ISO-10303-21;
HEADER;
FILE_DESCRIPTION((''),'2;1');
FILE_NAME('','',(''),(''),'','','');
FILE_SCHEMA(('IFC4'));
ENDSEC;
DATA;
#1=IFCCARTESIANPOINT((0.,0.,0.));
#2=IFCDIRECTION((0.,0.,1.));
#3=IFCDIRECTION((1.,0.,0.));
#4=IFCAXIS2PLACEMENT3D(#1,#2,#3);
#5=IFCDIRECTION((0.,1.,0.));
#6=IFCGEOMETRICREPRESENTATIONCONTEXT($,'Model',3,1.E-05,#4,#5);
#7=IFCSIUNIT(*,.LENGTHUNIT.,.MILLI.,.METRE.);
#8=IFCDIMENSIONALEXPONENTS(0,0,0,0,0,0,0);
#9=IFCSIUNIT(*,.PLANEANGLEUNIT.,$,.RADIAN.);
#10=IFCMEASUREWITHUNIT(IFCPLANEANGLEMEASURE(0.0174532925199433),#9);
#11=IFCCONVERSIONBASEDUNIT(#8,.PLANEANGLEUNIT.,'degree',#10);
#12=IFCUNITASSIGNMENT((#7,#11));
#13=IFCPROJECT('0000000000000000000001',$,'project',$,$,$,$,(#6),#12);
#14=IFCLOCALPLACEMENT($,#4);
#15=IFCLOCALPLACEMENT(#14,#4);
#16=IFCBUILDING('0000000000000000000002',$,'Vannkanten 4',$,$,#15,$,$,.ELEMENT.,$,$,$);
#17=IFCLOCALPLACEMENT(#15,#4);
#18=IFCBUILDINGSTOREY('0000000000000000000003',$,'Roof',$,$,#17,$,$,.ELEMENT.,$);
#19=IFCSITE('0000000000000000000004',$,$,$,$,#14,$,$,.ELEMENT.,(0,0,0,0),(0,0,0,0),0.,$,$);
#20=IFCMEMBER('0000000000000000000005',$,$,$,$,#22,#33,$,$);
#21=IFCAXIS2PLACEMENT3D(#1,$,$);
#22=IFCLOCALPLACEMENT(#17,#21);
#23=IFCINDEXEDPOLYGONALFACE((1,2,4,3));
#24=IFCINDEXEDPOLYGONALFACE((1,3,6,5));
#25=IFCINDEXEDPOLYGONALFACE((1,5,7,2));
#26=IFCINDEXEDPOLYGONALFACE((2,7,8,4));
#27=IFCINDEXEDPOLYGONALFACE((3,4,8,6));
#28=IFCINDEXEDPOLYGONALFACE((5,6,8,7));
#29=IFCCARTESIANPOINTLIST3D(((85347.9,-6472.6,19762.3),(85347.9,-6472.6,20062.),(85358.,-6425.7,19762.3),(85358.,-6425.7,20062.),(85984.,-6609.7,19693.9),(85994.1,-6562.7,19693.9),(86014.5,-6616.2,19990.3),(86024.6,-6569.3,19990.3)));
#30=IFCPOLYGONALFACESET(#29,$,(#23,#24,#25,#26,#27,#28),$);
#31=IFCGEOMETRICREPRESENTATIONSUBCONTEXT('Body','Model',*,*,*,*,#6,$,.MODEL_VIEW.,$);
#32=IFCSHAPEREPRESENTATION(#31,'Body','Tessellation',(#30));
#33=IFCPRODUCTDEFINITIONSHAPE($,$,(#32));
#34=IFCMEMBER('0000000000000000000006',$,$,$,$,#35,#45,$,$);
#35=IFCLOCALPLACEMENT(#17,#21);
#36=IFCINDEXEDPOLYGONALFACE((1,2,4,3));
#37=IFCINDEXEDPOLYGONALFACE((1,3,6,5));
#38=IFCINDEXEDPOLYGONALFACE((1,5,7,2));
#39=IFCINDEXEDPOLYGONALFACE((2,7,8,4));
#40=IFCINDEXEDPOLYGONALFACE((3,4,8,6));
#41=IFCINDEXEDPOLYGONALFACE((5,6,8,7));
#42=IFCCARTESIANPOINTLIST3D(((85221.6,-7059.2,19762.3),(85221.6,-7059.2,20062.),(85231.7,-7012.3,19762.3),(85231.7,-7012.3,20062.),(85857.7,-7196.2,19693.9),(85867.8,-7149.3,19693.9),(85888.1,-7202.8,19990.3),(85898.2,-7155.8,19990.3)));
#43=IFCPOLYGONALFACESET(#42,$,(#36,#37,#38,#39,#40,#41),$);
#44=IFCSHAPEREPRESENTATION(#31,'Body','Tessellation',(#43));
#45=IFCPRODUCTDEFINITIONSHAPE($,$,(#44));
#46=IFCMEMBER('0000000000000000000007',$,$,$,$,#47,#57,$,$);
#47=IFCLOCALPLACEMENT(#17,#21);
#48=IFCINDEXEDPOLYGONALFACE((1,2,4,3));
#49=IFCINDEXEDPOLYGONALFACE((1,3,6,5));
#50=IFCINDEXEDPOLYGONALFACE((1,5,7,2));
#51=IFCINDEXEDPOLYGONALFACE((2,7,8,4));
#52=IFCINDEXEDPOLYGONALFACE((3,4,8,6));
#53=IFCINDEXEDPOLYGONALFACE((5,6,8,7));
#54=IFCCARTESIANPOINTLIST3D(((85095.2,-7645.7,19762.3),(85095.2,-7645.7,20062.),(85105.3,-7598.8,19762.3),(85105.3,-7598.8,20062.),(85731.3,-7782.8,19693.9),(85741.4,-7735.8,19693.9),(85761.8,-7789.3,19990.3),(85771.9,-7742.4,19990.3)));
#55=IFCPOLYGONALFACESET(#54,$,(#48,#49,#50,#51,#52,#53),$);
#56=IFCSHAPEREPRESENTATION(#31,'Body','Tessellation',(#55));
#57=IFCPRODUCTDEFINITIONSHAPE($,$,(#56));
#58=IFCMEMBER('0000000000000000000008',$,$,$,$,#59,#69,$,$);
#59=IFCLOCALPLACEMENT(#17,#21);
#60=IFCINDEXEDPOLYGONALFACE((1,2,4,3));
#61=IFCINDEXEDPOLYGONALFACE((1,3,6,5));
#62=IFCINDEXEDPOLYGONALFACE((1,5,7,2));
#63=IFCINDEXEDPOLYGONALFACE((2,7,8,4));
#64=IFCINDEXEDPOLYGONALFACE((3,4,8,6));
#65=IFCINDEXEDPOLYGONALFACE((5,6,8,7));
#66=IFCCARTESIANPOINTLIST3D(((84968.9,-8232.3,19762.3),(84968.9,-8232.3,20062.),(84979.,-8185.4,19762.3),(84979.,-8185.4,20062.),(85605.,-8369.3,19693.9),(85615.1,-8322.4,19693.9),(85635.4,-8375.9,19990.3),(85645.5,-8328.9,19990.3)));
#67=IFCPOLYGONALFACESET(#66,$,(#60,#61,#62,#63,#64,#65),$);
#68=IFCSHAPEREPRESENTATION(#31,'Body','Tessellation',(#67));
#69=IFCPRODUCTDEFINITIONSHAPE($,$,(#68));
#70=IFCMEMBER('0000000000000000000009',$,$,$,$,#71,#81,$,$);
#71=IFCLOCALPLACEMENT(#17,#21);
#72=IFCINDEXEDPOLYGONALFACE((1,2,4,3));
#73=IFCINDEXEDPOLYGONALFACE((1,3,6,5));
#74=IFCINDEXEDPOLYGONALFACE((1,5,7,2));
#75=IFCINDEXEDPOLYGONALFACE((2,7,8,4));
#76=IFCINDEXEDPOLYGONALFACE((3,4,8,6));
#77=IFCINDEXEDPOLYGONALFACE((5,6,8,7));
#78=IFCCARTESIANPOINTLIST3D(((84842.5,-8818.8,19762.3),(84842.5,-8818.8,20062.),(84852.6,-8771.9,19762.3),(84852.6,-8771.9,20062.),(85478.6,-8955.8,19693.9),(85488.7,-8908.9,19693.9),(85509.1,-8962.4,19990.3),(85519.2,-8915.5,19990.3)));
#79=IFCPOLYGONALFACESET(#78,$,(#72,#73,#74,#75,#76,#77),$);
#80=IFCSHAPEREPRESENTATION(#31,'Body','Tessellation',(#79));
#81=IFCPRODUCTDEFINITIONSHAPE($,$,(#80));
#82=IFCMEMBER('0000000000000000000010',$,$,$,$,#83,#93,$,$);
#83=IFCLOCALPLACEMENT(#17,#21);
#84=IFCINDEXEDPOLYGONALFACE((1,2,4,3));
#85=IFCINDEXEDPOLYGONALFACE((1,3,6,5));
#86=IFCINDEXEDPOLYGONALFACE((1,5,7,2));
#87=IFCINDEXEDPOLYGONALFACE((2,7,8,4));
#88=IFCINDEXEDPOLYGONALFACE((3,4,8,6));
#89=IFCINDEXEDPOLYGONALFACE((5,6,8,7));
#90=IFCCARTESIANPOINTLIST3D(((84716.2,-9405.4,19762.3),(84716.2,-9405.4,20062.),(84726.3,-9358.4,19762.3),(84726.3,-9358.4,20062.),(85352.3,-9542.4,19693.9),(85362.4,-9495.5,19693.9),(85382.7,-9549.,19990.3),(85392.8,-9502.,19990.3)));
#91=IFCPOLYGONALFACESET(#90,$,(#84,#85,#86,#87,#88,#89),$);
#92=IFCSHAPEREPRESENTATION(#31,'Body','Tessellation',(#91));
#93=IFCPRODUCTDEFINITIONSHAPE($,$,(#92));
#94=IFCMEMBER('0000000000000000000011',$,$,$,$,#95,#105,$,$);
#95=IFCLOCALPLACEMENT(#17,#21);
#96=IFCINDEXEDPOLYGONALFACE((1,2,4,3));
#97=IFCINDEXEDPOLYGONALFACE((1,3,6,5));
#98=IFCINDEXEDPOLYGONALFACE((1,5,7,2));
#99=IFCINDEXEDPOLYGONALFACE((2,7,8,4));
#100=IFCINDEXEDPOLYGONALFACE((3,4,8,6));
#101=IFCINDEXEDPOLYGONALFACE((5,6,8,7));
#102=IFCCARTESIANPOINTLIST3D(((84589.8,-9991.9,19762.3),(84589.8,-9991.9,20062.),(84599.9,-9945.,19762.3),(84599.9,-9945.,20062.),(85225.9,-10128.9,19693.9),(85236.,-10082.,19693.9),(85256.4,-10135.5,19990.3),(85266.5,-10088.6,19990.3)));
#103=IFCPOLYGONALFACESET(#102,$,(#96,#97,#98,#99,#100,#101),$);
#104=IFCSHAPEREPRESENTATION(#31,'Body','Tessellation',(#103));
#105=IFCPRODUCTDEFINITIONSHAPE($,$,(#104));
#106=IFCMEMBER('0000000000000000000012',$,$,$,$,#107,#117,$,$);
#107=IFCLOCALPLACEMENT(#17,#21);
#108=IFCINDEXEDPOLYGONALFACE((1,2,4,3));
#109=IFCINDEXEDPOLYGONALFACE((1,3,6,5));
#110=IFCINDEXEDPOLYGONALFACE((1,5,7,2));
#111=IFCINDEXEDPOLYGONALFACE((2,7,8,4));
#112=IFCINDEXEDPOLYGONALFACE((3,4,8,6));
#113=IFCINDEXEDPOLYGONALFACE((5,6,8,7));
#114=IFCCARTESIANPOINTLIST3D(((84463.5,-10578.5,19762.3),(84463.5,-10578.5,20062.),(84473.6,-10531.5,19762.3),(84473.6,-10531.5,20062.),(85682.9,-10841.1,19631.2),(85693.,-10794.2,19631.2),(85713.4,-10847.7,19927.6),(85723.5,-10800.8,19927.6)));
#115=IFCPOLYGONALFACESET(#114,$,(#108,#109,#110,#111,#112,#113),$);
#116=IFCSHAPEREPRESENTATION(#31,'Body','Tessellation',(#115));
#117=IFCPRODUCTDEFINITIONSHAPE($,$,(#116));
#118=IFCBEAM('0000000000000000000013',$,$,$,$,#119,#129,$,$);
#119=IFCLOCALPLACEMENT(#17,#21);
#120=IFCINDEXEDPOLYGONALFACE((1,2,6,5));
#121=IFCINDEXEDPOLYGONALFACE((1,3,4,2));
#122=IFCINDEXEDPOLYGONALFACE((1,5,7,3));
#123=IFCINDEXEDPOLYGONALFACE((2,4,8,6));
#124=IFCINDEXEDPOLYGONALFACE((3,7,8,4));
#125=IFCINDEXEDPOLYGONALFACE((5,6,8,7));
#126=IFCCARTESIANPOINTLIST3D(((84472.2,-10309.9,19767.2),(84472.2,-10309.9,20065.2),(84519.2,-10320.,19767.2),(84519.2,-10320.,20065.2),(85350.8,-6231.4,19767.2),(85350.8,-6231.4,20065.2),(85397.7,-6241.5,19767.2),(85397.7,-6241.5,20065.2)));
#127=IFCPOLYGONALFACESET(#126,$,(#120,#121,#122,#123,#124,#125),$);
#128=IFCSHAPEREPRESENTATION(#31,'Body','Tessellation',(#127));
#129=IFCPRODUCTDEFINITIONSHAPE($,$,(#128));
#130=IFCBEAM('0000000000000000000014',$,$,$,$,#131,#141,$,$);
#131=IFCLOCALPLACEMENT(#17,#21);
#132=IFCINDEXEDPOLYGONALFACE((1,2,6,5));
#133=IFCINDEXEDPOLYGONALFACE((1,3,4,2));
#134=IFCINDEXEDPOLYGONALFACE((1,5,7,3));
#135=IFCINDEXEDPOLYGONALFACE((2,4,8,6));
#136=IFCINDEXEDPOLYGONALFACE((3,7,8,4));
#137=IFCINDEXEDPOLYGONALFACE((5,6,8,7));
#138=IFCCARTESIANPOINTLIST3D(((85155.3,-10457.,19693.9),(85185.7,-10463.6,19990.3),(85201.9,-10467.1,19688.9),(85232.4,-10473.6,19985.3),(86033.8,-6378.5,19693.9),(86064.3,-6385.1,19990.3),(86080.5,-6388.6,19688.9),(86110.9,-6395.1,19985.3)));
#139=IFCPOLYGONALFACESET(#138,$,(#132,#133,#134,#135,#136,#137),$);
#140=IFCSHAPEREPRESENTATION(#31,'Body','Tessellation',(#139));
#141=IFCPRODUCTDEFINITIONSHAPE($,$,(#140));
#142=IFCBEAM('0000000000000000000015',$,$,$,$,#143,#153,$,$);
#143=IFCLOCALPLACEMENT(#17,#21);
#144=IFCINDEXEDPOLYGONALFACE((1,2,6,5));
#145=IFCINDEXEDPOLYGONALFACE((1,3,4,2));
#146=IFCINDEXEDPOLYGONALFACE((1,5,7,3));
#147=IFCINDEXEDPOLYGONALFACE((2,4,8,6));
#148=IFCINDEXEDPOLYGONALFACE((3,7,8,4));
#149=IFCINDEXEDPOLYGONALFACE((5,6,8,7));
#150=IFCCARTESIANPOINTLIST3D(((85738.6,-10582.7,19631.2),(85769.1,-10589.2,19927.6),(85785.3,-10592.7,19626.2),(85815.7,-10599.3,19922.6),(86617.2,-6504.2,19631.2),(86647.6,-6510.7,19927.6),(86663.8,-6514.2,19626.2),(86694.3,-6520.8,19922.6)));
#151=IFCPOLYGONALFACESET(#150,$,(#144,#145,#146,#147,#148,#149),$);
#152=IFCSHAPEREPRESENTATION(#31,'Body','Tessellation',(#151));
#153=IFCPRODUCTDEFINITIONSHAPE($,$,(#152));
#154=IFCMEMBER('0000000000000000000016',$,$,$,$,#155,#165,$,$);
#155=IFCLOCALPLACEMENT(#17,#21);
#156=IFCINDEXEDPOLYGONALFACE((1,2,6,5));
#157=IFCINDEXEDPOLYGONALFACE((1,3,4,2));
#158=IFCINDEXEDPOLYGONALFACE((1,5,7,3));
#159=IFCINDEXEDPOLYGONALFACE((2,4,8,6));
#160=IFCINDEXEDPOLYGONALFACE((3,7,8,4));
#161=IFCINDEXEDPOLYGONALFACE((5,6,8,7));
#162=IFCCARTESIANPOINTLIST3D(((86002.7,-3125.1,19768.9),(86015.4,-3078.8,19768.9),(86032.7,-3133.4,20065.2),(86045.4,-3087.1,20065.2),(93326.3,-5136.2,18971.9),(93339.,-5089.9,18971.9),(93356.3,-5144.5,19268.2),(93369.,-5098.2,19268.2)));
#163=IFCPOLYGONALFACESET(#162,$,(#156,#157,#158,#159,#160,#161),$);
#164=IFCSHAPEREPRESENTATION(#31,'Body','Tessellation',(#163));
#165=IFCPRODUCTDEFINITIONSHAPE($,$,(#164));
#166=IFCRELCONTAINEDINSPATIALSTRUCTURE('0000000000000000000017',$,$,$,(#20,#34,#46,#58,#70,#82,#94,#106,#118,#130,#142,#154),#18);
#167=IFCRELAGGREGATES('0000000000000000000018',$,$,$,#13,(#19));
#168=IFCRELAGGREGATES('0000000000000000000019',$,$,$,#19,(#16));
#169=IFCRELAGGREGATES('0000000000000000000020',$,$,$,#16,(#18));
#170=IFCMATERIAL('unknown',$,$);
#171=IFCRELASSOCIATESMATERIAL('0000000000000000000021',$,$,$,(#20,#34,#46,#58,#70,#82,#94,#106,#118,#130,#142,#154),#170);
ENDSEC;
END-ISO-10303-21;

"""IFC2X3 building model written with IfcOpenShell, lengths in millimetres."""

from ifc_helpers import new_model, entity, si_unit, converted_unit, direction, frame, origin_with_axes, place, context, subcontext, project, spatial, polyline, segment, composite_curve, outline, extrude, clip, halfspace, material, element, save


model = new_model("IFC2X3")

# Units and contexts
model_context = context("Model", 3, precision=1e-05, world=origin_with_axes(), true_north=direction((0.0, 1.0, 0.0)))
body_context = subcontext(model_context, "Body", "Model", "MODEL_VIEW")
ifc_project = project(units=[si_unit("LENGTHUNIT", "METRE", prefix="MILLI"), converted_unit("PLANEANGLEUNIT", "degree", entity("IfcPlaneAngleMeasure", 0.0174532925199433), si_unit("PLANEANGLEUNIT", "RADIAN"), dimensions=[0, 0, 0, 0, 0, 0, 0])], contexts=[model_context])

# Site, building, storey
site_placement = place(None, origin_with_axes())
site = spatial("IfcSite", under=ifc_project, at=site_placement, CompositionType="ELEMENT", RefLatitude=(0, 0, 0, 0), RefLongitude=(0, 0, 0, 0), RefElevation=0.0)
building_placement = place(site_placement, origin_with_axes())
building = spatial("IfcBuilding", under=site, at=building_placement, Name="Vannkanten 4", CompositionType="ELEMENT")
storey_placement = place(building_placement, origin_with_axes())
storey = spatial("IfcBuildingStorey", under=building, at=storey_placement, Name="Roof", CompositionType="ELEMENT")

# Shared definitions
ifc_material = material(Name="unknown")

# Members
member_1_placement = place(storey_placement, frame((86004.3, -6589.5, 19842.1), z_axis=(-0.972221, 0.209428, 0.104528), x_axis=(-0.210582, -0.977576, 0.0)))
element("IfcMember", 1, at=member_1_placement, inside=storey, material=ifc_material, context=body_context, shape_type="Clipping", body=[
    clip(extrude(outline(composite_curve([segment(polyline([(-24.0, -149.0), (-24.0, 149.0), (24.0, 149.0), (24.0, -149.0), (-24.0, -149.0)]), True, "CONTINUOUS")], self_intersect=False)), frame((0.0, 0.0, 0.0), z_axis=(0.0, 0.0, 1.0), x_axis=(1.0, 0.0, 0.0)), (0.0, 0.0, 1.0), 1028.4), halfspace(frame((-24.0, -149.0, 654.3), z_axis=(0.0, 0.104528, -0.994522), x_axis=(0.0, -0.994522, -0.104528)), True)),
])
member_2_placement = place(storey_placement, frame((85878.0, -7176.0, 19842.1), z_axis=(-0.972221, 0.209428, 0.104528), x_axis=(-0.210582, -0.977576, 0.0)))
element("IfcMember", 2, at=member_2_placement, inside=storey, material=ifc_material, context=body_context, shape_type="Clipping", body=[
    clip(extrude(outline(composite_curve([segment(polyline([(-24.0, -149.0), (-24.0, 149.0), (24.0, 149.0), (24.0, -149.0), (-24.0, -149.0)]), True, "CONTINUOUS")], self_intersect=False)), frame((0.0, 0.0, 0.0), z_axis=(0.0, 0.0, 1.0), x_axis=(1.0, 0.0, 0.0)), (0.0, 0.0, 1.0), 1028.4), halfspace(frame((-24.0, -149.0, 654.3), z_axis=(0.0, 0.104528, -0.994522), x_axis=(0.0, -0.994522, -0.104528)), True)),
])
member_3_placement = place(storey_placement, frame((85751.6, -7762.6, 19842.1), z_axis=(-0.972221, 0.209428, 0.104528), x_axis=(-0.210582, -0.977576, 0.0)))
element("IfcMember", 3, at=member_3_placement, inside=storey, material=ifc_material, context=body_context, shape_type="Clipping", body=[
    clip(extrude(outline(composite_curve([segment(polyline([(-24.0, -149.0), (-24.0, 149.0), (24.0, 149.0), (24.0, -149.0), (-24.0, -149.0)]), True, "CONTINUOUS")], self_intersect=False)), frame((0.0, 0.0, 0.0), z_axis=(0.0, 0.0, 1.0), x_axis=(1.0, 0.0, 0.0)), (0.0, 0.0, 1.0), 1028.4), halfspace(frame((-24.0, -149.0, 654.3), z_axis=(0.0, 0.104528, -0.994522), x_axis=(0.0, -0.994522, -0.104528)), True)),
])
member_4_placement = place(storey_placement, frame((85625.3, -8349.1, 19842.1), z_axis=(-0.972221, 0.209428, 0.104528), x_axis=(-0.210582, -0.977576, 0.0)))
element("IfcMember", 4, at=member_4_placement, inside=storey, material=ifc_material, context=body_context, shape_type="Clipping", body=[
    clip(extrude(outline(composite_curve([segment(polyline([(-24.0, -149.0), (-24.0, 149.0), (24.0, 149.0), (24.0, -149.0), (-24.0, -149.0)]), True, "CONTINUOUS")], self_intersect=False)), frame((0.0, 0.0, 0.0), z_axis=(0.0, 0.0, 1.0), x_axis=(1.0, 0.0, 0.0)), (0.0, 0.0, 1.0), 1028.4), halfspace(frame((-24.0, -149.0, 654.3), z_axis=(0.0, 0.104528, -0.994522), x_axis=(0.0, -0.994522, -0.104528)), True)),
])
member_5_placement = place(storey_placement, frame((85498.9, -8935.7, 19842.1), z_axis=(-0.972221, 0.209428, 0.104528), x_axis=(-0.210582, -0.977576, 0.0)))
element("IfcMember", 5, at=member_5_placement, inside=storey, material=ifc_material, context=body_context, shape_type="Clipping", body=[
    clip(extrude(outline(composite_curve([segment(polyline([(-24.0, -149.0), (-24.0, 149.0), (24.0, 149.0), (24.0, -149.0), (-24.0, -149.0)]), True, "CONTINUOUS")], self_intersect=False)), frame((0.0, 0.0, 0.0), z_axis=(0.0, 0.0, 1.0), x_axis=(1.0, 0.0, 0.0)), (0.0, 0.0, 1.0), 1028.4), halfspace(frame((-24.0, -149.0, 654.3), z_axis=(0.0, 0.104528, -0.994522), x_axis=(0.0, -0.994522, -0.104528)), True)),
])
member_6_placement = place(storey_placement, frame((85372.6, -9522.2, 19842.1), z_axis=(-0.972221, 0.209428, 0.104528), x_axis=(-0.210582, -0.977576, 0.0)))
element("IfcMember", 6, at=member_6_placement, inside=storey, material=ifc_material, context=body_context, shape_type="Clipping", body=[
    clip(extrude(outline(composite_curve([segment(polyline([(-24.0, -149.0), (-24.0, 149.0), (24.0, 149.0), (24.0, -149.0), (-24.0, -149.0)]), True, "CONTINUOUS")], self_intersect=False)), frame((0.0, 0.0, 0.0), z_axis=(0.0, 0.0, 1.0), x_axis=(1.0, 0.0, 0.0)), (0.0, 0.0, 1.0), 1028.4), halfspace(frame((-24.0, -149.0, 654.3), z_axis=(0.0, 0.104528, -0.994522), x_axis=(0.0, -0.994522, -0.104528)), True)),
])
member_7_placement = place(storey_placement, frame((85246.2, -10108.8, 19842.1), z_axis=(-0.972221, 0.209428, 0.104528), x_axis=(-0.210582, -0.977576, 0.0)))
element("IfcMember", 7, at=member_7_placement, inside=storey, material=ifc_material, context=body_context, shape_type="Clipping", body=[
    clip(extrude(outline(composite_curve([segment(polyline([(-24.0, -149.0), (-24.0, 149.0), (24.0, 149.0), (24.0, -149.0), (-24.0, -149.0)]), True, "CONTINUOUS")], self_intersect=False)), frame((0.0, 0.0, 0.0), z_axis=(0.0, 0.0, 1.0), x_axis=(1.0, 0.0, 0.0)), (0.0, 0.0, 1.0), 1028.4), halfspace(frame((-24.0, -149.0, 654.3), z_axis=(0.0, 0.104528, -0.994522), x_axis=(0.0, -0.994522, -0.104528)), True)),
])
member_8_placement = place(storey_placement, frame((85703.2, -10821.0, 19779.4), z_axis=(-0.972221, 0.209428, 0.104528), x_axis=(-0.210582, -0.977576, 0.0)))
element("IfcMember", 8, at=member_8_placement, inside=storey, material=ifc_material, context=body_context, shape_type="Clipping", body=[
    clip(extrude(outline(composite_curve([segment(polyline([(-24.0, -149.0), (-24.0, 149.0), (24.0, 149.0), (24.0, -149.0), (-24.0, -149.0)]), True, "CONTINUOUS")], self_intersect=False)), frame((0.0, 0.0, 0.0), z_axis=(0.0, 0.0, 1.0), x_axis=(1.0, 0.0, 0.0)), (0.0, 0.0, 1.0), 1928.4), halfspace(frame((-24.0, -149.0, 1254.3), z_axis=(0.0, 0.104528, -0.994522), x_axis=(0.0, -0.994522, -0.104528)), True)),
])

# Beams
beam_1_placement = place(storey_placement, frame((84495.7, -10315.0, 19916.2), z_axis=(0.210582, 0.977576, 0.0), x_axis=(-0.977576, 0.210582, 0.0)))
element("IfcBeam", 9, at=beam_1_placement, inside=storey, material=ifc_material, context=body_context, shape_type="SweptSolid", body=[
    extrude(outline(composite_curve([segment(polyline([(-24.0, -149.0), (-24.0, 149.0), (24.0, 149.0), (24.0, -149.0), (-24.0, -149.0)]), True, "CONTINUOUS")], self_intersect=False)), frame((0.0, 0.0, 0.0), z_axis=(0.0, 0.0, 1.0), x_axis=(1.0, 0.0, 0.0)), (0.0, 0.0, 1.0), 4172.1),
])
beam_2_placement = place(storey_placement, frame((85193.8, -10465.3, 19839.6), z_axis=(0.210582, 0.977576, 0.0), x_axis=(-0.972221, 0.209428, 0.104528)))
element("IfcBeam", 10, at=beam_2_placement, inside=storey, material=ifc_material, context=body_context, shape_type="SweptSolid", body=[
    extrude(outline(composite_curve([segment(polyline([(-24.0, -149.0), (-24.0, 149.0), (24.0, 149.0), (24.0, -149.0), (-24.0, -149.0)]), True, "CONTINUOUS")], self_intersect=False)), frame((0.0, 0.0, 0.0), z_axis=(0.0, 0.0, 1.0), x_axis=(1.0, 0.0, 0.0)), (0.0, 0.0, 1.0), 4172.0),
])
beam_3_placement = place(storey_placement, frame((85777.2, -10591.0, 19776.9), z_axis=(0.210582, 0.977576, 0.0), x_axis=(-0.972221, 0.209428, 0.104528)))
element("IfcBeam", 11, at=beam_3_placement, inside=storey, material=ifc_material, context=body_context, shape_type="SweptSolid", body=[
    extrude(outline(composite_curve([segment(polyline([(-24.0, -149.0), (-24.0, 149.0), (24.0, 149.0), (24.0, -149.0), (-24.0, -149.0)]), True, "CONTINUOUS")], self_intersect=False)), frame((0.0, 0.0, 0.0), z_axis=(0.0, 0.0, 1.0), x_axis=(1.0, 0.0, 0.0)), (0.0, 0.0, 1.0), 4172.0),
])

# Member
member_9_placement = place(storey_placement, frame((86024.0, -3106.1, 19917.0), z_axis=(0.959037, -0.263355, -0.104367), x_axis=(0.264801, 0.964303, 0.0)))
element("IfcMember", 12, at=member_9_placement, inside=storey, material=ifc_material, context=body_context, shape_type="SweptSolid", body=[
    extrude(outline(composite_curve([segment(polyline([(-24.0, -149.0), (-24.0, 149.0), (24.0, 149.0), (24.0, -149.0), (-24.0, -149.0)]), True, "CONTINUOUS")], self_intersect=False)), frame((0.0, 0.0, 0.0), z_axis=(0.0, 0.0, 1.0), x_axis=(1.0, 0.0, 0.0)), (0.0, 0.0, 1.0), 7636.4),
])

save(model, "model.ifc")
